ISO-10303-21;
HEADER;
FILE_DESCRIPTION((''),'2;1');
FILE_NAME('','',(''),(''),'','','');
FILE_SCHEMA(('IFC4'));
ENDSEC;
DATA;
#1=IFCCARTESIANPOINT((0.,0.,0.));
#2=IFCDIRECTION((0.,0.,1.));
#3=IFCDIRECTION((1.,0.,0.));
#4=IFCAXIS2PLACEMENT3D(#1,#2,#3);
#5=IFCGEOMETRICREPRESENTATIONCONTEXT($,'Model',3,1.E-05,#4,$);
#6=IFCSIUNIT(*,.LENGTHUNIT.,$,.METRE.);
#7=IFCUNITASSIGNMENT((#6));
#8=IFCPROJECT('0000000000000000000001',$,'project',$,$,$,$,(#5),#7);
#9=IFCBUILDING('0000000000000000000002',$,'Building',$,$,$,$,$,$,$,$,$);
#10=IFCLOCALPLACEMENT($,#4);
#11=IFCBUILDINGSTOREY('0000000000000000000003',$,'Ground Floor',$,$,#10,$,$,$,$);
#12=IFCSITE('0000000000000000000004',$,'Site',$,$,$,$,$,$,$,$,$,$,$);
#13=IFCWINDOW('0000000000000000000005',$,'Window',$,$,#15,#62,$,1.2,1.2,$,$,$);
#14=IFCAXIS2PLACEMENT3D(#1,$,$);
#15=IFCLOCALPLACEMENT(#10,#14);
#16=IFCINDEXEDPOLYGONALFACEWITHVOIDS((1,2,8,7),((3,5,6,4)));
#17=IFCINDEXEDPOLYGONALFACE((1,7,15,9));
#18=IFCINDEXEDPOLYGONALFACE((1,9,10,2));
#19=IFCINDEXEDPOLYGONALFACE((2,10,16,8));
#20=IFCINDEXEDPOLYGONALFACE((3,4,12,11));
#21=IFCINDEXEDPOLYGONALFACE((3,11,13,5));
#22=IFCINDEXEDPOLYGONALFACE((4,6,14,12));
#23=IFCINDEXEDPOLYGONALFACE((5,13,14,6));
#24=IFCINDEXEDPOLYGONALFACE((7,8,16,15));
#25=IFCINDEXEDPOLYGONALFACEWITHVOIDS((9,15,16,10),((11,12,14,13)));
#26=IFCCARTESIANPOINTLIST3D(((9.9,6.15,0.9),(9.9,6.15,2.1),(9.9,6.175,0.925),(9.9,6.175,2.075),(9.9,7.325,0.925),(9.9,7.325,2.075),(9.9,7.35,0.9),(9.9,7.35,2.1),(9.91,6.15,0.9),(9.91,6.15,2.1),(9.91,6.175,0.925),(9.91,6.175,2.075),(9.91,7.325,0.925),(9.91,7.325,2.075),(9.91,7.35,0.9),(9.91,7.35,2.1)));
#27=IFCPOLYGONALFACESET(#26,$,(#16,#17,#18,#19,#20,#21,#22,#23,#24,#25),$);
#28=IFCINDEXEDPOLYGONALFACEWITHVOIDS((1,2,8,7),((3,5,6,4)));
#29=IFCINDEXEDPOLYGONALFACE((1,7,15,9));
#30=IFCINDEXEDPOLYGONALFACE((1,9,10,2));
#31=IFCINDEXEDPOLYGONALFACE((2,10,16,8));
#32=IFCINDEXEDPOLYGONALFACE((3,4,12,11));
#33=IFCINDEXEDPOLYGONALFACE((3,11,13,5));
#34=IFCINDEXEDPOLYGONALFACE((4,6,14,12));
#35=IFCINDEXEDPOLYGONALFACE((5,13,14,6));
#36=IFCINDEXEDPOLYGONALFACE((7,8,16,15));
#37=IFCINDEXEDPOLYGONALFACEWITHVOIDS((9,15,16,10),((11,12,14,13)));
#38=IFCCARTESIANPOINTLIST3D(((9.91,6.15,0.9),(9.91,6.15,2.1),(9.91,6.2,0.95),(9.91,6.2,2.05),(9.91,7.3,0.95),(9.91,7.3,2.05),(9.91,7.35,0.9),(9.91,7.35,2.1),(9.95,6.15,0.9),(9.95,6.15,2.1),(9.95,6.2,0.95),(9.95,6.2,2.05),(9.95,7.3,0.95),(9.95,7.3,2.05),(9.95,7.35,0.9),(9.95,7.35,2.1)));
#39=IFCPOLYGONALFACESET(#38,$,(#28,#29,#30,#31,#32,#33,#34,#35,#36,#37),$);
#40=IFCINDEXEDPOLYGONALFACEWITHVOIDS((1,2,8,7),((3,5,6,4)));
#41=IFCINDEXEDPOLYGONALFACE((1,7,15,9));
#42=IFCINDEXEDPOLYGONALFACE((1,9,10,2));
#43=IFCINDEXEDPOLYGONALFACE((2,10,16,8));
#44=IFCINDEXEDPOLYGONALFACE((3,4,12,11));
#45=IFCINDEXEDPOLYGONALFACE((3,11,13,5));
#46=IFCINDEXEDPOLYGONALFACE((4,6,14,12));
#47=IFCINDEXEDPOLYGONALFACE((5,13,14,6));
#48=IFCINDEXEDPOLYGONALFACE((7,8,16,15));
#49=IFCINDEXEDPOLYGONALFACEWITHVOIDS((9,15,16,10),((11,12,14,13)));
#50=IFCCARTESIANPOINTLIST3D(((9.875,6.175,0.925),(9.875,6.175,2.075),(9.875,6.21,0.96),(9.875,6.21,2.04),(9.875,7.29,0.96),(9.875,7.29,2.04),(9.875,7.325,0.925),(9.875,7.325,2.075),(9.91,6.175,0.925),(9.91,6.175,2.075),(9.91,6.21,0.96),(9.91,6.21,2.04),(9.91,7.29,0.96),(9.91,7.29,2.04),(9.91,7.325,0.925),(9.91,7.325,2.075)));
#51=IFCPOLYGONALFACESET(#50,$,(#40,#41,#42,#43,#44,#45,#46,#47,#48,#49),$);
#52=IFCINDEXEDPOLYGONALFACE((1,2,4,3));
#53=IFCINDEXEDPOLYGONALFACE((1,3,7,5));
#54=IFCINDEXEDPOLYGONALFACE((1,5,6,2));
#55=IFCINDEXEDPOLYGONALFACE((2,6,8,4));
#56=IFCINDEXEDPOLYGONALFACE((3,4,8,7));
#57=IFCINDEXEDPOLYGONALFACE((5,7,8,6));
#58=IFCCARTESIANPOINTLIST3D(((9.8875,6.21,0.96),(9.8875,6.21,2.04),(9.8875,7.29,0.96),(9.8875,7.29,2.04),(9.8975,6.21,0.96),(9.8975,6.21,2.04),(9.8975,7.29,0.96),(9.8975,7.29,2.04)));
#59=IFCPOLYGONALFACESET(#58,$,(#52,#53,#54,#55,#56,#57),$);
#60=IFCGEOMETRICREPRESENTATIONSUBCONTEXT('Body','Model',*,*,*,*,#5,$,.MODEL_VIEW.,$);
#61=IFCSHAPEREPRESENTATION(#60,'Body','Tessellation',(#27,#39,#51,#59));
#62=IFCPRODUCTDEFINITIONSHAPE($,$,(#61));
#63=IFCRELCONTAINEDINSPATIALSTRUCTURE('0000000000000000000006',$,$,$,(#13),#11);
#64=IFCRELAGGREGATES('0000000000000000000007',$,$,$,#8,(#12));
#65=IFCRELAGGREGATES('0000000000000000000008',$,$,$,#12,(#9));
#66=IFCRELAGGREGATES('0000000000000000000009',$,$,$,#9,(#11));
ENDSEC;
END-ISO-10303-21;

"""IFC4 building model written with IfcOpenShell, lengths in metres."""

from ifc_helpers import new_model, si_unit, frame, origin_with_axes, place, context, subcontext, project, spatial, line, indexed_curve, outline, extrude, element, save


model = new_model("IFC4")

# Units and contexts
model_context = context("Model", 3, precision=1e-05, world=origin_with_axes())
body_context = subcontext(model_context, "Body", "Model", "MODEL_VIEW")
ifc_project = project(units=[si_unit("LENGTHUNIT", "METRE")], contexts=[model_context])

# Site, building, storey
site = spatial("IfcSite", under=ifc_project, Name="Site")
building = spatial("IfcBuilding", under=site, Name="Building")
storey_placement = place(None, origin_with_axes())
storey = spatial("IfcBuildingStorey", under=building, at=storey_placement, Name="Ground Floor")

# Window
window_1_placement = place(storey_placement, frame((10.0, 6.15, 0.9), z_axis=(0.0, 0.0, 1.0), x_axis=(0.0, 1.0, 0.0)))
element("IfcWindow", 1, at=window_1_placement, inside=storey, Name="Window", OverallHeight=1.2, OverallWidth=1.2, context=body_context, shape_type="SweptSolid", body=[
    extrude(outline(indexed_curve([(0.0, 0.0), (1.2, 0.0), (1.2, 1.2), (0.0, 1.2)], segments=[line(1, 2, 3, 4, 1)]), holes=[indexed_curve([(0.025, 0.025), (1.175, 0.025), (1.175, 1.175), (0.025, 1.175)], segments=[line(1, 2, 3, 4, 1)])]), frame((0.0, 0.09, 0.0), z_axis=(0.0, -1.0, 0.0), x_axis=(1.0, 0.0, 0.0)), (0.0, 0.0, -1.0), 0.01),
    extrude(outline(indexed_curve([(0.0, 0.0), (1.2, 0.0), (1.2, 1.2), (0.0, 1.2)], segments=[line(1, 2, 3, 4, 1)]), holes=[indexed_curve([(0.05, 0.05), (1.15, 0.05), (1.15, 1.15), (0.05, 1.15)], segments=[line(1, 2, 3, 4, 1)])]), frame((0.0, 0.05, 0.0), z_axis=(0.0, -1.0, 0.0), x_axis=(1.0, 0.0, 0.0)), (0.0, 0.0, -1.0), 0.04),
    extrude(outline(indexed_curve([(0.0, 0.0), (1.15, 0.0), (1.15, 1.15), (0.0, 1.15)], segments=[line(1, 2, 3, 4, 1)]), holes=[indexed_curve([(0.035, 0.035), (1.115, 0.035), (1.115, 1.115), (0.035, 1.115)], segments=[line(1, 2, 3, 4, 1)])]), frame((0.025, 0.09, 0.025), z_axis=(0.0, -1.0, 0.0), x_axis=(1.0, 0.0, 0.0)), (0.0, 0.0, -1.0), 0.035),
    extrude(outline(indexed_curve([(0.035, 0.035), (1.115, 0.035), (1.115, 1.115), (0.035, 1.115)], segments=[line(1, 2, 3, 4, 1)])), frame((0.025, 0.1025, 0.025), z_axis=(0.0, -1.0, 0.0), x_axis=(1.0, 0.0, 0.0)), (0.0, 0.0, -1.0), 0.01),
])

save(model, "model.ifc")
